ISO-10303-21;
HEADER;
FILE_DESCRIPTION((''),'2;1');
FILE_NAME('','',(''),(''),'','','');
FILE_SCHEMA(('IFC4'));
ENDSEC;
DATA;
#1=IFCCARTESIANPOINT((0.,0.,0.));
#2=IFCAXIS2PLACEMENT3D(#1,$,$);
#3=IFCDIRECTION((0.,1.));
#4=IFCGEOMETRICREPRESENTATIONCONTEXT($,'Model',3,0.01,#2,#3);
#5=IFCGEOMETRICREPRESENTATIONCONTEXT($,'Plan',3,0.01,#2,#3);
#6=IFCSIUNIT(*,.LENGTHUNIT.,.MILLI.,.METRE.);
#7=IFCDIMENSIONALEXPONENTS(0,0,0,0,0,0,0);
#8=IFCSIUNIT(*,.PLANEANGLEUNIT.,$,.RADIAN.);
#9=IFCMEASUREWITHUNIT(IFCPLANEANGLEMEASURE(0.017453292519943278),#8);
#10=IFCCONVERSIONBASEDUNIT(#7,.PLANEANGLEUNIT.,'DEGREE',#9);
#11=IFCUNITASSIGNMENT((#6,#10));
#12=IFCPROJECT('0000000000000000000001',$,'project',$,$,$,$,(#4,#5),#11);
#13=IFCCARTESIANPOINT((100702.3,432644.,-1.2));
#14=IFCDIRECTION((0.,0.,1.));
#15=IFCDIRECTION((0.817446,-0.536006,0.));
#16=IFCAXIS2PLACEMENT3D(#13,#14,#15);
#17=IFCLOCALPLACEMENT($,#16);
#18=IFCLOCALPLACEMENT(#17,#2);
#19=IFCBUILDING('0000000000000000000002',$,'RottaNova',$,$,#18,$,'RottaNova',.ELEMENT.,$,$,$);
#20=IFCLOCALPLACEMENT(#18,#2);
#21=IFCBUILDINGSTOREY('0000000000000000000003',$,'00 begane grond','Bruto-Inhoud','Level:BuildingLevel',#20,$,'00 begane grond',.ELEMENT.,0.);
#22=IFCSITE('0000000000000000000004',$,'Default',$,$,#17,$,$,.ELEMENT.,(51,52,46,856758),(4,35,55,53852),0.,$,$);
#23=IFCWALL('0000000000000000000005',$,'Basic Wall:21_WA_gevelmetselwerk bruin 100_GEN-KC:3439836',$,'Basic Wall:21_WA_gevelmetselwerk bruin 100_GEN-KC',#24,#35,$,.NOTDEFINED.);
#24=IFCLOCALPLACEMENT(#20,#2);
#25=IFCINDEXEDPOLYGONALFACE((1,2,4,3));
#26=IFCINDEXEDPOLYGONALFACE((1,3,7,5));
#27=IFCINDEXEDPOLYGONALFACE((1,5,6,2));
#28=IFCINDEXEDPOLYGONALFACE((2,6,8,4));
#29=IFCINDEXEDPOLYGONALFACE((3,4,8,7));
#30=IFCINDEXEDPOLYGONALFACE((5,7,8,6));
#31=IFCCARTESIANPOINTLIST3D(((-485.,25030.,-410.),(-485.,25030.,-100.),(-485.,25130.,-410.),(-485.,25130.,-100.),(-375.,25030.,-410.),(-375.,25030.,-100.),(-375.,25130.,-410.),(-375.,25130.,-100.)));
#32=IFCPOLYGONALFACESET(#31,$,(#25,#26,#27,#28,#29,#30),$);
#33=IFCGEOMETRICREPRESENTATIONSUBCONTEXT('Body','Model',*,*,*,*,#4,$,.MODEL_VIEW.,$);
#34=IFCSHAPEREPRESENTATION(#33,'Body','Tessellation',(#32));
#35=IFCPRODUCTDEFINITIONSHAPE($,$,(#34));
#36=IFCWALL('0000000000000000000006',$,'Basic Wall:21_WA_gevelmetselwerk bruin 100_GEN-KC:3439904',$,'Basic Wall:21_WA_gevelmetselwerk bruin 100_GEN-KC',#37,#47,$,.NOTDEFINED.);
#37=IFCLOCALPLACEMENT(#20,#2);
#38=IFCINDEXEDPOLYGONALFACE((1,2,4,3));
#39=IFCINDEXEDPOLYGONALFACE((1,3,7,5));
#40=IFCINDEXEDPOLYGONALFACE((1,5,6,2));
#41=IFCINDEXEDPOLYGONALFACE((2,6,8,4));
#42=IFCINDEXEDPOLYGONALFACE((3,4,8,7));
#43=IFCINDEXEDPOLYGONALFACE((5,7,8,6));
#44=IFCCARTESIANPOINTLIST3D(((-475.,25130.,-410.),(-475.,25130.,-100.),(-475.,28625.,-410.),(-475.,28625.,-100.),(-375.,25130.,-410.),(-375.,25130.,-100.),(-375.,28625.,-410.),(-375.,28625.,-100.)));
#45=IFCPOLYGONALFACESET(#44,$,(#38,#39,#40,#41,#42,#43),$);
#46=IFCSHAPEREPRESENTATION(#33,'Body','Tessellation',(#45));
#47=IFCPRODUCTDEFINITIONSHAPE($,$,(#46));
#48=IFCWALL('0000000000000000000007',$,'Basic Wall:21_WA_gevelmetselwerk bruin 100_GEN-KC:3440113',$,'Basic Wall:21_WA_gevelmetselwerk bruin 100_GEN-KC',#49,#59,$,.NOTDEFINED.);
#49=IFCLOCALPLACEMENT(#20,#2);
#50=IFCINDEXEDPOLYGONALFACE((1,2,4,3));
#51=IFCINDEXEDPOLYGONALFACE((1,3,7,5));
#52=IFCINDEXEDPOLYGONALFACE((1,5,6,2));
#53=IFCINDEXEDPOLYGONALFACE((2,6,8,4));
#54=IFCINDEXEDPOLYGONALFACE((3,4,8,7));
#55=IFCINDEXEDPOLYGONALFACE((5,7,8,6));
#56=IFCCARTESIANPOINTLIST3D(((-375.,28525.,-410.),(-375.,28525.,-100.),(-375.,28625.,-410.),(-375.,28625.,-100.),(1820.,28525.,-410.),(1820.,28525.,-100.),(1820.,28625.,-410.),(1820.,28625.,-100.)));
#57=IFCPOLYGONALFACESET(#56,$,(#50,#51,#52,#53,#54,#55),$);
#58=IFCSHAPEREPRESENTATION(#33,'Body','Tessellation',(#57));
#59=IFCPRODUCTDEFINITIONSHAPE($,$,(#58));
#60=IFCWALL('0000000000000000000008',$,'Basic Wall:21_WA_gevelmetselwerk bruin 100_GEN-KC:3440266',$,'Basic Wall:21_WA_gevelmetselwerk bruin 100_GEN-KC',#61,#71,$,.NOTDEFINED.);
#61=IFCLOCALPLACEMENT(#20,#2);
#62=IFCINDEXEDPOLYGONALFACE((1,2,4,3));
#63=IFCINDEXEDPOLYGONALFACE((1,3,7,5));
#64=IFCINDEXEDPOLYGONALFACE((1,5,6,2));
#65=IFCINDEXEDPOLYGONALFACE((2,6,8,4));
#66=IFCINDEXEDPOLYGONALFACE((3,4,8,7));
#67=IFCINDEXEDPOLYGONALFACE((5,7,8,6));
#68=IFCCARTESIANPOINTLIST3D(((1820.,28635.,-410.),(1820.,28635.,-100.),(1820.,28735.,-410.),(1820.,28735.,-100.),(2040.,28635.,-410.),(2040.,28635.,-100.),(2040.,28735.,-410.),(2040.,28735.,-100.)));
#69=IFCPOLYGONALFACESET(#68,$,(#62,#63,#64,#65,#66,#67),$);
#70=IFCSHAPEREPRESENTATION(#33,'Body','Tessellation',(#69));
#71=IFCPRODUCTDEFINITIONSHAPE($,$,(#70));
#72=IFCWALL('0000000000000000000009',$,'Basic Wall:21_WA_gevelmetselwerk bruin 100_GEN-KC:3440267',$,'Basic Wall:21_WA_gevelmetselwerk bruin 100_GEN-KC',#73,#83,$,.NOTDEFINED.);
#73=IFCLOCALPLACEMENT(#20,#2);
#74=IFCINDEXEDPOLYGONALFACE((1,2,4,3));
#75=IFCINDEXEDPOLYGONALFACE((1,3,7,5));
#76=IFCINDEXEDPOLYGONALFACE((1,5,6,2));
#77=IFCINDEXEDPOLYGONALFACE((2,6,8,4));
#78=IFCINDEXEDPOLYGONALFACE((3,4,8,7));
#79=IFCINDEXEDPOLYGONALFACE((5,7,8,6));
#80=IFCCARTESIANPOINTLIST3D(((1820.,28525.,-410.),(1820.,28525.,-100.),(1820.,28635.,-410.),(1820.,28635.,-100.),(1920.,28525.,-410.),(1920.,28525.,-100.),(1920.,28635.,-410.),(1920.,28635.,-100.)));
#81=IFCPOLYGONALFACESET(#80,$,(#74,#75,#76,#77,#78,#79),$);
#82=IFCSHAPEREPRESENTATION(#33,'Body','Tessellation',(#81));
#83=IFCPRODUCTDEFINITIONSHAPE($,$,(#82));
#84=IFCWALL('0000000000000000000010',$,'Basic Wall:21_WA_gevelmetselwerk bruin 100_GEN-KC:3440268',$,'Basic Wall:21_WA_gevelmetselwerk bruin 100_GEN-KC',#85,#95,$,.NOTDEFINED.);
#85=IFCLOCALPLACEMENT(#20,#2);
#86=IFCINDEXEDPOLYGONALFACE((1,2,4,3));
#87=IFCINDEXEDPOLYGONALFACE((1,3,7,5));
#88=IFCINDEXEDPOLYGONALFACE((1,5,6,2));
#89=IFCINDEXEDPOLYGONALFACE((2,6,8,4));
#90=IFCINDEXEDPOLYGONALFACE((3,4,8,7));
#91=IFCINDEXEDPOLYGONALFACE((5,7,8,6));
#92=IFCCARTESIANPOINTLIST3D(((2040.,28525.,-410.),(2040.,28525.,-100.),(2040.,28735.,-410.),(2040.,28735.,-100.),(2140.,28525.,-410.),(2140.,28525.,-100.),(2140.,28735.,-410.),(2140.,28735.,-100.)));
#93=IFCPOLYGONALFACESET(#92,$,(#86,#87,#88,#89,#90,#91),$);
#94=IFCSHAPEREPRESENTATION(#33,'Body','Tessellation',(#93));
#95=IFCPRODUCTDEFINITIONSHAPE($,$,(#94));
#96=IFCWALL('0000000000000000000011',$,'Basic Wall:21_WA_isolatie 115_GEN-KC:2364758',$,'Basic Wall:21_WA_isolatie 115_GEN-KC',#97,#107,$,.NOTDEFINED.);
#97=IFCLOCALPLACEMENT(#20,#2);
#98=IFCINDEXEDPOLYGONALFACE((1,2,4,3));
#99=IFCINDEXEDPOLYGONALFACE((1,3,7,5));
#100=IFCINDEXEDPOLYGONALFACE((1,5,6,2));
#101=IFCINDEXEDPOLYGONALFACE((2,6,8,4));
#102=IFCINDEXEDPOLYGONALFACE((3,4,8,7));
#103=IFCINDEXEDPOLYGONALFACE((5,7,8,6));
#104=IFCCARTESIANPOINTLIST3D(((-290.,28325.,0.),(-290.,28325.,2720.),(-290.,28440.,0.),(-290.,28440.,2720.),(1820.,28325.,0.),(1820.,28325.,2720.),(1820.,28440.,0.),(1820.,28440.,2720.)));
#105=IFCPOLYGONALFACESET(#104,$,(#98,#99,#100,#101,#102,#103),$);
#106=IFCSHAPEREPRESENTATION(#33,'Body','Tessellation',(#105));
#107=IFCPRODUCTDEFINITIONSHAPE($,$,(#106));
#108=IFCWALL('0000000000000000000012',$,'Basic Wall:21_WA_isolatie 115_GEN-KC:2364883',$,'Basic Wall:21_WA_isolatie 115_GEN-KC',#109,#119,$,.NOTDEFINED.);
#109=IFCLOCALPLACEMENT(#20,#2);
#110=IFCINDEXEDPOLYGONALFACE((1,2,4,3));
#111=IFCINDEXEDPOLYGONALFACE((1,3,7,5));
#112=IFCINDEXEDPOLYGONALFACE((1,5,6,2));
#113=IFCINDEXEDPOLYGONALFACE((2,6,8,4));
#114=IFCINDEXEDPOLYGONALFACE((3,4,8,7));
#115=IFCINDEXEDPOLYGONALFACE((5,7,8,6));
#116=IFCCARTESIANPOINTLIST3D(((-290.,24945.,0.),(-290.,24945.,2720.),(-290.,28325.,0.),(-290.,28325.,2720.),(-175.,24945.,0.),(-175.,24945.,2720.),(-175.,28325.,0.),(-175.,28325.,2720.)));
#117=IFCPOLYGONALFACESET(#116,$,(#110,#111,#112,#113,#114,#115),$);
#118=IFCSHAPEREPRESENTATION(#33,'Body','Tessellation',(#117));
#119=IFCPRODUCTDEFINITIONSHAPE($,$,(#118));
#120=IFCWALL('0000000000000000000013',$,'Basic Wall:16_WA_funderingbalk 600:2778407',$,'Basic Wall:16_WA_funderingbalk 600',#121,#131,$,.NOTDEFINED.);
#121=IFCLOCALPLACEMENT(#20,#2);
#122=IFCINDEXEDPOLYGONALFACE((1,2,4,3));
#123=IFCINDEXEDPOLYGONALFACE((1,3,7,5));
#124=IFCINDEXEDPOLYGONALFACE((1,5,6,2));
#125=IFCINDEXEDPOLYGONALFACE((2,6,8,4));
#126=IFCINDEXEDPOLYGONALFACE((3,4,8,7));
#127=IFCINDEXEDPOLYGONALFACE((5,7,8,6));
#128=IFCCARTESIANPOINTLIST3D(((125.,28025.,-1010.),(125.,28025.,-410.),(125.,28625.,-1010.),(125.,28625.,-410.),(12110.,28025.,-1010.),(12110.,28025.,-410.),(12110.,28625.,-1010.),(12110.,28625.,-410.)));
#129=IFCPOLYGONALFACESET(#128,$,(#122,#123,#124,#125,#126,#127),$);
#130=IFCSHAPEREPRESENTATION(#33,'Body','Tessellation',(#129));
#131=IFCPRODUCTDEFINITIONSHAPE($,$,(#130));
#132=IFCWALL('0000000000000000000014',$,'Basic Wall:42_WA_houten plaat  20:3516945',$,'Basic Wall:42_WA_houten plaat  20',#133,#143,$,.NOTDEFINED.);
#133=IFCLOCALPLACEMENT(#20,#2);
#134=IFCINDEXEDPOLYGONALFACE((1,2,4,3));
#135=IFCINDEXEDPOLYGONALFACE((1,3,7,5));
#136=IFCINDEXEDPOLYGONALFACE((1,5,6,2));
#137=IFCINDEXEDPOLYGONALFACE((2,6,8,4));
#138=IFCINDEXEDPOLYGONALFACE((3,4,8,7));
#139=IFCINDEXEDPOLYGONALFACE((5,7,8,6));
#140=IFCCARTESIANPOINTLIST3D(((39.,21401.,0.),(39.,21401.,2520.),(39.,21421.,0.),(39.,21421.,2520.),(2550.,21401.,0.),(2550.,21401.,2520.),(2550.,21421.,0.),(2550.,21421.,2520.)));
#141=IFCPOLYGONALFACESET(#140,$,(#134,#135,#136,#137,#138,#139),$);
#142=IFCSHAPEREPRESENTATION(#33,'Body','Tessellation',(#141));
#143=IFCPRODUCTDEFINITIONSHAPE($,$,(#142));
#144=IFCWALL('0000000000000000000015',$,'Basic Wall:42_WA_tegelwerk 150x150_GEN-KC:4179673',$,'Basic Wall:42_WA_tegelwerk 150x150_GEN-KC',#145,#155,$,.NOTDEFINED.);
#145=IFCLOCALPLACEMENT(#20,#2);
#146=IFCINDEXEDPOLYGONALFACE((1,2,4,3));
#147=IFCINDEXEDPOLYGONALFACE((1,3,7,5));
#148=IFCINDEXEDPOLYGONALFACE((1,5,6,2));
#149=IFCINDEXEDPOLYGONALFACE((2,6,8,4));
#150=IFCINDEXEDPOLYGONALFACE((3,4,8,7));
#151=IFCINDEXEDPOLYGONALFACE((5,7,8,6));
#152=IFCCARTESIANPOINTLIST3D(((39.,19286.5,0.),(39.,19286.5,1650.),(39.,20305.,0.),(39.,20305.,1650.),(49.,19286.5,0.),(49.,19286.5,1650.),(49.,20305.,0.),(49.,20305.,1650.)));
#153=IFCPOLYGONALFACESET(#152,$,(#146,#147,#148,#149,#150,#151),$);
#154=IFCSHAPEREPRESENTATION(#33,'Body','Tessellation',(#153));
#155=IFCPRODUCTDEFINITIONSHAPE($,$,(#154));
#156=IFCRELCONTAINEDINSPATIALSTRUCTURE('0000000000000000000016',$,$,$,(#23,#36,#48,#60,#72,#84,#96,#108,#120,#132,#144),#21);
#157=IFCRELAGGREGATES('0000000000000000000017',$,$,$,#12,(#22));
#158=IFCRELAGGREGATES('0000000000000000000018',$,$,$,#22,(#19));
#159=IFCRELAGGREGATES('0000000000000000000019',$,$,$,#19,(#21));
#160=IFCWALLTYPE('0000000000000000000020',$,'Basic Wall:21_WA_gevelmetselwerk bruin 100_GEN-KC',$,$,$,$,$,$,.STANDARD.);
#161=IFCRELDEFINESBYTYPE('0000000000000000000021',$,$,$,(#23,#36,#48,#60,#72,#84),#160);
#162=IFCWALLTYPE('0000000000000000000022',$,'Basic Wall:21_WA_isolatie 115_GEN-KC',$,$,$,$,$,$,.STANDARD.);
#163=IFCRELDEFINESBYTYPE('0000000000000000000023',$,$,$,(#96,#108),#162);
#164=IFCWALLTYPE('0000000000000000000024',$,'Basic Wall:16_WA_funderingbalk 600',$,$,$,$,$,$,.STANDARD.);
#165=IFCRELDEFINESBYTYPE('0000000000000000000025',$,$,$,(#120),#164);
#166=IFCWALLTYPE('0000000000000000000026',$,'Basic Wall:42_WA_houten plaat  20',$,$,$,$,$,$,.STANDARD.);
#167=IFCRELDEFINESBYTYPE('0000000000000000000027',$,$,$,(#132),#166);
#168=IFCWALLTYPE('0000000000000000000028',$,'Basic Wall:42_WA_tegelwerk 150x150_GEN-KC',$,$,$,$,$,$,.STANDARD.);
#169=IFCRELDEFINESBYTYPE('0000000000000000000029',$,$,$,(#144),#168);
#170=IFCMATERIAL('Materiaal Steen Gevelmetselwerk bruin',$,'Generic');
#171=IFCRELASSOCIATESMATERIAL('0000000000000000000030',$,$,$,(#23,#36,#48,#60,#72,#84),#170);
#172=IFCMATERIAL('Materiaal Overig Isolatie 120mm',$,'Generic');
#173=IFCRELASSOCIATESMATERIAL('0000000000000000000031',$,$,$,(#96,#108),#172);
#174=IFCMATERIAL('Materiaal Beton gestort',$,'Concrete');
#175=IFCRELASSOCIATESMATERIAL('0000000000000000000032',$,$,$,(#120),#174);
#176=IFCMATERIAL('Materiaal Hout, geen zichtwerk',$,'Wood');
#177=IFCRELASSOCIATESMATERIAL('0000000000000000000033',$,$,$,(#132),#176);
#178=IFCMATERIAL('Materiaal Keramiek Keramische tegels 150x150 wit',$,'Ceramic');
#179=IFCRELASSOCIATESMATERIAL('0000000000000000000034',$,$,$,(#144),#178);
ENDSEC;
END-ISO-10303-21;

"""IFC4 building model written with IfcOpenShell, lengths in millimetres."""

from ifc_helpers import new_model, entity, si_unit, converted_unit, direction, frame, origin, place, context, subcontext, project, spatial, indexed_curve, outline, extrude, material, type_object, element, save


model = new_model("IFC4")

# Units and contexts
model_context = context("Model", 3, precision=0.01, world=origin(), true_north=direction((0.0, 1.0)))
plan_context = context("Plan", 3, precision=0.01, world=origin(), true_north=direction((0.0, 1.0)))
body_context = subcontext(model_context, "Body", "Model", "MODEL_VIEW")
ifc_project = project(units=[si_unit("LENGTHUNIT", "METRE", prefix="MILLI"), converted_unit("PLANEANGLEUNIT", "DEGREE", entity("IfcPlaneAngleMeasure", 0.017453292519943278), si_unit("PLANEANGLEUNIT", "RADIAN"), dimensions=[0, 0, 0, 0, 0, 0, 0])], contexts=[model_context, plan_context])

# Site, building, storey
site_placement = place(None, frame((100702.3, 432644.0, -1.2), z_axis=(0.0, 0.0, 1.0), x_axis=(0.817446, -0.536006, 0.0)))
site = spatial("IfcSite", under=ifc_project, at=site_placement, Name="Default", CompositionType="ELEMENT", RefLatitude=(51, 52, 46, 856758), RefLongitude=(4, 35, 55, 53852), RefElevation=0.0)
building_placement = place(site_placement, origin())
building = spatial("IfcBuilding", under=site, at=building_placement, Name="RottaNova", LongName="RottaNova", CompositionType="ELEMENT")
storey_placement = place(building_placement, origin())
storey = spatial("IfcBuildingStorey", under=building, at=storey_placement, Name="00 begane grond", Description="Bruto-Inhoud", ObjectType="Level:BuildingLevel", LongName="00 begane grond", CompositionType="ELEMENT", Elevation=0.0)

# Walls
ifc_material_1 = material(Name="Materiaal Steen Gevelmetselwerk bruin", Category="Generic")
wall_type_1 = type_object("IfcWallType", Name="Basic Wall:21_WA_gevelmetselwerk bruin 100_GEN-KC", PredefinedType="STANDARD")
wall_1_placement = place(storey_placement, frame((-485.0, 25080.0, -410.0)))
element("IfcWall", 1, at=wall_1_placement, inside=storey, type_object=wall_type_1, material=ifc_material_1, Name="Basic Wall:21_WA_gevelmetselwerk bruin 100_GEN-KC:3439836", ObjectType="Basic Wall:21_WA_gevelmetselwerk bruin 100_GEN-KC", PredefinedType="NOTDEFINED", context=body_context, shape_type="SweptSolid", body=[
    extrude(outline(indexed_curve([(110.0, 50.0), (0.0, 50.0), (0.0, -50.0), (110.0, -50.0), (110.0, 50.0)], self_intersect=False)), origin(), (0.0, 0.0, 1.0), 310.0),
])
wall_2_placement = place(storey_placement, frame((-425.0, 25130.0, -410.0), z_axis=(0.0, 0.0, 1.0), x_axis=(0.0, 1.0, 0.0)))
element("IfcWall", 2, at=wall_2_placement, inside=storey, type_object=wall_type_1, material=ifc_material_1, Name="Basic Wall:21_WA_gevelmetselwerk bruin 100_GEN-KC:3439904", ObjectType="Basic Wall:21_WA_gevelmetselwerk bruin 100_GEN-KC", PredefinedType="NOTDEFINED", context=body_context, shape_type="SweptSolid", body=[
    extrude(outline(indexed_curve([(3495.0, 50.0), (0.0, 50.0), (0.0, -50.0), (3495.0, -50.0), (3495.0, 50.0)], self_intersect=False)), origin(), (0.0, 0.0, 1.0), 310.0),
])
wall_3_placement = place(storey_placement, frame((1820.0, 28575.0, -410.0), z_axis=(0.0, 0.0, 1.0), x_axis=(-1.0, 0.0, 0.0)))
element("IfcWall", 3, at=wall_3_placement, inside=storey, type_object=wall_type_1, material=ifc_material_1, Name="Basic Wall:21_WA_gevelmetselwerk bruin 100_GEN-KC:3440113", ObjectType="Basic Wall:21_WA_gevelmetselwerk bruin 100_GEN-KC", PredefinedType="NOTDEFINED", context=body_context, shape_type="SweptSolid", body=[
    extrude(outline(indexed_curve([(2195.0, 50.0), (0.0, 50.0), (0.0, -50.0), (2195.0, -50.0), (2195.0, 50.0)], self_intersect=False)), origin(), (0.0, 0.0, 1.0), 310.0),
])
wall_4_placement = place(storey_placement, frame((1820.0, 28685.0, -410.0)))
element("IfcWall", 4, at=wall_4_placement, inside=storey, type_object=wall_type_1, material=ifc_material_1, Name="Basic Wall:21_WA_gevelmetselwerk bruin 100_GEN-KC:3440266", ObjectType="Basic Wall:21_WA_gevelmetselwerk bruin 100_GEN-KC", PredefinedType="NOTDEFINED", context=body_context, shape_type="SweptSolid", body=[
    extrude(outline(indexed_curve([(220.0, 50.0), (0.0, 50.0), (0.0, -50.0), (220.0, -50.0), (220.0, 50.0)], self_intersect=False)), origin(), (0.0, 0.0, 1.0), 310.0),
])
wall_5_placement = place(storey_placement, frame((1870.0, 28635.0, -410.0), z_axis=(0.0, 0.0, 1.0), x_axis=(0.0, -1.0, 0.0)))
element("IfcWall", 5, at=wall_5_placement, inside=storey, type_object=wall_type_1, material=ifc_material_1, Name="Basic Wall:21_WA_gevelmetselwerk bruin 100_GEN-KC:3440267", ObjectType="Basic Wall:21_WA_gevelmetselwerk bruin 100_GEN-KC", PredefinedType="NOTDEFINED", context=body_context, shape_type="SweptSolid", body=[
    extrude(outline(indexed_curve([(110.0, 50.0), (0.0, 50.0), (0.0, -50.0), (110.0, -50.0), (110.0, 50.0)], self_intersect=False)), origin(), (0.0, 0.0, 1.0), 310.0),
])
wall_6_placement = place(storey_placement, frame((2090.0, 28735.0, -410.0), z_axis=(0.0, 0.0, 1.0), x_axis=(0.0, -1.0, 0.0)))
element("IfcWall", 6, at=wall_6_placement, inside=storey, type_object=wall_type_1, material=ifc_material_1, Name="Basic Wall:21_WA_gevelmetselwerk bruin 100_GEN-KC:3440268", ObjectType="Basic Wall:21_WA_gevelmetselwerk bruin 100_GEN-KC", PredefinedType="NOTDEFINED", context=body_context, shape_type="SweptSolid", body=[
    extrude(outline(indexed_curve([(210.0, 50.0), (0.0, 50.0), (0.0, -50.0), (210.0, -50.0), (210.0, 50.0)], self_intersect=False)), origin(), (0.0, 0.0, 1.0), 310.0),
])
ifc_material_2 = material(Name="Materiaal Overig Isolatie 120mm", Category="Generic")
wall_type_2 = type_object("IfcWallType", Name="Basic Wall:21_WA_isolatie 115_GEN-KC", PredefinedType="STANDARD")
wall_7_placement = place(storey_placement, frame((1820.0, 28382.5, 0.0), z_axis=(0.0, 0.0, 1.0), x_axis=(-1.0, 0.0, 0.0)))
element("IfcWall", 7, at=wall_7_placement, inside=storey, type_object=wall_type_2, material=ifc_material_2, Name="Basic Wall:21_WA_isolatie 115_GEN-KC:2364758", ObjectType="Basic Wall:21_WA_isolatie 115_GEN-KC", PredefinedType="NOTDEFINED", context=body_context, shape_type="SweptSolid", body=[
    extrude(outline(indexed_curve([(2110.0, 57.5), (0.0, 57.5), (0.0, -57.5), (2110.0, -57.5), (2110.0, 57.5)], self_intersect=False)), origin(), (0.0, 0.0, 1.0), 2720.0),
])
wall_8_placement = place(storey_placement, frame((-232.5, 24945.0, 0.0), z_axis=(0.0, 0.0, 1.0), x_axis=(0.0, 1.0, 0.0)))
element("IfcWall", 8, at=wall_8_placement, inside=storey, type_object=wall_type_2, material=ifc_material_2, Name="Basic Wall:21_WA_isolatie 115_GEN-KC:2364883", ObjectType="Basic Wall:21_WA_isolatie 115_GEN-KC", PredefinedType="NOTDEFINED", context=body_context, shape_type="SweptSolid", body=[
    extrude(outline(indexed_curve([(3380.0, 57.5), (0.0, 57.5), (0.0, -57.5), (3380.0, -57.5), (3380.0, 57.5)], self_intersect=False)), origin(), (0.0, 0.0, 1.0), 2720.0),
])
ifc_material_3 = material(Name="Materiaal Beton gestort", Category="Concrete")
wall_type_3 = type_object("IfcWallType", Name="Basic Wall:16_WA_funderingbalk 600", PredefinedType="STANDARD")
wall_9_placement = place(storey_placement, frame((125.0, 28325.0, -1010.0)))
element("IfcWall", 9, at=wall_9_placement, inside=storey, type_object=wall_type_3, material=ifc_material_3, Name="Basic Wall:16_WA_funderingbalk 600:2778407", ObjectType="Basic Wall:16_WA_funderingbalk 600", PredefinedType="NOTDEFINED", context=body_context, shape_type="SweptSolid", body=[
    extrude(outline(indexed_curve([(11985.0, 300.0), (0.0, 300.0), (0.0, -300.0), (11985.0, -300.0), (11985.0, 300.0)], self_intersect=False)), origin(), (0.0, 0.0, 1.0), 600.0),
])
ifc_material_4 = material(Name="Materiaal Hout, geen zichtwerk", Category="Wood")
wall_type_4 = type_object("IfcWallType", Name="Basic Wall:42_WA_houten plaat  20", PredefinedType="STANDARD")
wall_10_placement = place(storey_placement, frame((39.0, 21411.0, 0.0)))
element("IfcWall", 10, at=wall_10_placement, inside=storey, type_object=wall_type_4, material=ifc_material_4, Name="Basic Wall:42_WA_houten plaat  20:3516945", ObjectType="Basic Wall:42_WA_houten plaat  20", PredefinedType="NOTDEFINED", context=body_context, shape_type="SweptSolid", body=[
    extrude(outline(indexed_curve([(2511.0, 10.0), (0.0, 10.0), (0.0, -10.0), (2511.0, -10.0), (2511.0, 10.0)], self_intersect=False)), origin(), (0.0, 0.0, 1.0), 2520.0),
])
ifc_material_5 = material(Name="Materiaal Keramiek Keramische tegels 150x150 wit", Category="Ceramic")
wall_type_5 = type_object("IfcWallType", Name="Basic Wall:42_WA_tegelwerk 150x150_GEN-KC", PredefinedType="STANDARD")
wall_11_placement = place(storey_placement, frame((44.0, 20305.0, 0.0), z_axis=(0.0, 0.0, 1.0), x_axis=(0.0, -1.0, 0.0)))
element("IfcWall", 11, at=wall_11_placement, inside=storey, type_object=wall_type_5, material=ifc_material_5, Name="Basic Wall:42_WA_tegelwerk 150x150_GEN-KC:4179673", ObjectType="Basic Wall:42_WA_tegelwerk 150x150_GEN-KC", PredefinedType="NOTDEFINED", context=body_context, shape_type="SweptSolid", body=[
    extrude(outline(indexed_curve([(1018.5, 5.0), (0.0, 5.0), (0.0, -5.0), (1018.5, -5.0), (1018.5, 5.0)], self_intersect=False)), origin(), (0.0, 0.0, 1.0), 1650.0),
])

save(model, "model.ifc")
